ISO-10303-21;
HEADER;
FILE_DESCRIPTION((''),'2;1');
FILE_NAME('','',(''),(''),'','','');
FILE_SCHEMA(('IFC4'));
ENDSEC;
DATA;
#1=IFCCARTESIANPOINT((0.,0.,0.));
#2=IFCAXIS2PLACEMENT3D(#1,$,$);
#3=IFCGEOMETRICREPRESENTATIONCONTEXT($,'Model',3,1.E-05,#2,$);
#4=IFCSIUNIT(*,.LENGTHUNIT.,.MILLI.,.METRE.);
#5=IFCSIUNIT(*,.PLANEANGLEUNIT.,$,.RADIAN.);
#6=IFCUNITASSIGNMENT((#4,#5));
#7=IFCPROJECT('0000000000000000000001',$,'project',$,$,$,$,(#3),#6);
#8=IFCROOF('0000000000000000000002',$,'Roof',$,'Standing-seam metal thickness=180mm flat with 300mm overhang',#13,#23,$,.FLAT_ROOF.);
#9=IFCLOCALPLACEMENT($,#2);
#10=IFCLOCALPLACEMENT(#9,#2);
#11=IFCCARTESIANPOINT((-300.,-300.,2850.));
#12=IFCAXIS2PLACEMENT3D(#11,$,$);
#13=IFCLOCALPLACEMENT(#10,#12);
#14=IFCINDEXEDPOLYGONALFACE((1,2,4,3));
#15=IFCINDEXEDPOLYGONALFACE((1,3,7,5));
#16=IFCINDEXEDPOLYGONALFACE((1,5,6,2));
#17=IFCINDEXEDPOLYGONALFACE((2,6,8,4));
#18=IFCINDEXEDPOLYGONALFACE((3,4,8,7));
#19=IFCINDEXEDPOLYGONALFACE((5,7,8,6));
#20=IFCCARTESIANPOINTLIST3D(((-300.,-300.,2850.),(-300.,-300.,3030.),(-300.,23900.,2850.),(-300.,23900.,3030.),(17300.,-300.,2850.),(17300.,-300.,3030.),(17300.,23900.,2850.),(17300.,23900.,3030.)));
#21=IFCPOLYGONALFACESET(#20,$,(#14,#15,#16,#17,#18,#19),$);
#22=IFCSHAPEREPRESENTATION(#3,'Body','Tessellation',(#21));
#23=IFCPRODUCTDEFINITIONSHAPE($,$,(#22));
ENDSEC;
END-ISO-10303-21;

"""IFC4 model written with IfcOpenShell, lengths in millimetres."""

from ifc_helpers import new_model, si_unit, frame, frame_2d, origin, place, context, project, rectangle, extrude, element, save


model = new_model("IFC4")

# Units and contexts
model_context = context("Model", 3, precision=1e-05, world=origin())
ifc_project = project(units=[si_unit("LENGTHUNIT", "METRE", prefix="MILLI"), si_unit("PLANEANGLEUNIT", "RADIAN")], contexts=[model_context])

# Roof
placement_1 = place(None, origin())
placement_2 = place(placement_1, origin())
roof_placement = place(placement_2, frame((-300.0, -300.0, 2850.0)))
element("IfcRoof", 1, at=roof_placement, Name="Roof", ObjectType="Standing-seam metal thickness=180mm flat with 300mm overhang", PredefinedType="FLAT_ROOF", context=model_context, shape_type="SweptSolid", body=[
    extrude(rectangle(XDim=17600.0, YDim=24200.0, at=frame_2d((8800.0, 12100.0))), frame((-300.0, -300.0, 2850.0)), (0.0, 0.0, 1.0), 180.0),
])

save(model, "model.ifc")
